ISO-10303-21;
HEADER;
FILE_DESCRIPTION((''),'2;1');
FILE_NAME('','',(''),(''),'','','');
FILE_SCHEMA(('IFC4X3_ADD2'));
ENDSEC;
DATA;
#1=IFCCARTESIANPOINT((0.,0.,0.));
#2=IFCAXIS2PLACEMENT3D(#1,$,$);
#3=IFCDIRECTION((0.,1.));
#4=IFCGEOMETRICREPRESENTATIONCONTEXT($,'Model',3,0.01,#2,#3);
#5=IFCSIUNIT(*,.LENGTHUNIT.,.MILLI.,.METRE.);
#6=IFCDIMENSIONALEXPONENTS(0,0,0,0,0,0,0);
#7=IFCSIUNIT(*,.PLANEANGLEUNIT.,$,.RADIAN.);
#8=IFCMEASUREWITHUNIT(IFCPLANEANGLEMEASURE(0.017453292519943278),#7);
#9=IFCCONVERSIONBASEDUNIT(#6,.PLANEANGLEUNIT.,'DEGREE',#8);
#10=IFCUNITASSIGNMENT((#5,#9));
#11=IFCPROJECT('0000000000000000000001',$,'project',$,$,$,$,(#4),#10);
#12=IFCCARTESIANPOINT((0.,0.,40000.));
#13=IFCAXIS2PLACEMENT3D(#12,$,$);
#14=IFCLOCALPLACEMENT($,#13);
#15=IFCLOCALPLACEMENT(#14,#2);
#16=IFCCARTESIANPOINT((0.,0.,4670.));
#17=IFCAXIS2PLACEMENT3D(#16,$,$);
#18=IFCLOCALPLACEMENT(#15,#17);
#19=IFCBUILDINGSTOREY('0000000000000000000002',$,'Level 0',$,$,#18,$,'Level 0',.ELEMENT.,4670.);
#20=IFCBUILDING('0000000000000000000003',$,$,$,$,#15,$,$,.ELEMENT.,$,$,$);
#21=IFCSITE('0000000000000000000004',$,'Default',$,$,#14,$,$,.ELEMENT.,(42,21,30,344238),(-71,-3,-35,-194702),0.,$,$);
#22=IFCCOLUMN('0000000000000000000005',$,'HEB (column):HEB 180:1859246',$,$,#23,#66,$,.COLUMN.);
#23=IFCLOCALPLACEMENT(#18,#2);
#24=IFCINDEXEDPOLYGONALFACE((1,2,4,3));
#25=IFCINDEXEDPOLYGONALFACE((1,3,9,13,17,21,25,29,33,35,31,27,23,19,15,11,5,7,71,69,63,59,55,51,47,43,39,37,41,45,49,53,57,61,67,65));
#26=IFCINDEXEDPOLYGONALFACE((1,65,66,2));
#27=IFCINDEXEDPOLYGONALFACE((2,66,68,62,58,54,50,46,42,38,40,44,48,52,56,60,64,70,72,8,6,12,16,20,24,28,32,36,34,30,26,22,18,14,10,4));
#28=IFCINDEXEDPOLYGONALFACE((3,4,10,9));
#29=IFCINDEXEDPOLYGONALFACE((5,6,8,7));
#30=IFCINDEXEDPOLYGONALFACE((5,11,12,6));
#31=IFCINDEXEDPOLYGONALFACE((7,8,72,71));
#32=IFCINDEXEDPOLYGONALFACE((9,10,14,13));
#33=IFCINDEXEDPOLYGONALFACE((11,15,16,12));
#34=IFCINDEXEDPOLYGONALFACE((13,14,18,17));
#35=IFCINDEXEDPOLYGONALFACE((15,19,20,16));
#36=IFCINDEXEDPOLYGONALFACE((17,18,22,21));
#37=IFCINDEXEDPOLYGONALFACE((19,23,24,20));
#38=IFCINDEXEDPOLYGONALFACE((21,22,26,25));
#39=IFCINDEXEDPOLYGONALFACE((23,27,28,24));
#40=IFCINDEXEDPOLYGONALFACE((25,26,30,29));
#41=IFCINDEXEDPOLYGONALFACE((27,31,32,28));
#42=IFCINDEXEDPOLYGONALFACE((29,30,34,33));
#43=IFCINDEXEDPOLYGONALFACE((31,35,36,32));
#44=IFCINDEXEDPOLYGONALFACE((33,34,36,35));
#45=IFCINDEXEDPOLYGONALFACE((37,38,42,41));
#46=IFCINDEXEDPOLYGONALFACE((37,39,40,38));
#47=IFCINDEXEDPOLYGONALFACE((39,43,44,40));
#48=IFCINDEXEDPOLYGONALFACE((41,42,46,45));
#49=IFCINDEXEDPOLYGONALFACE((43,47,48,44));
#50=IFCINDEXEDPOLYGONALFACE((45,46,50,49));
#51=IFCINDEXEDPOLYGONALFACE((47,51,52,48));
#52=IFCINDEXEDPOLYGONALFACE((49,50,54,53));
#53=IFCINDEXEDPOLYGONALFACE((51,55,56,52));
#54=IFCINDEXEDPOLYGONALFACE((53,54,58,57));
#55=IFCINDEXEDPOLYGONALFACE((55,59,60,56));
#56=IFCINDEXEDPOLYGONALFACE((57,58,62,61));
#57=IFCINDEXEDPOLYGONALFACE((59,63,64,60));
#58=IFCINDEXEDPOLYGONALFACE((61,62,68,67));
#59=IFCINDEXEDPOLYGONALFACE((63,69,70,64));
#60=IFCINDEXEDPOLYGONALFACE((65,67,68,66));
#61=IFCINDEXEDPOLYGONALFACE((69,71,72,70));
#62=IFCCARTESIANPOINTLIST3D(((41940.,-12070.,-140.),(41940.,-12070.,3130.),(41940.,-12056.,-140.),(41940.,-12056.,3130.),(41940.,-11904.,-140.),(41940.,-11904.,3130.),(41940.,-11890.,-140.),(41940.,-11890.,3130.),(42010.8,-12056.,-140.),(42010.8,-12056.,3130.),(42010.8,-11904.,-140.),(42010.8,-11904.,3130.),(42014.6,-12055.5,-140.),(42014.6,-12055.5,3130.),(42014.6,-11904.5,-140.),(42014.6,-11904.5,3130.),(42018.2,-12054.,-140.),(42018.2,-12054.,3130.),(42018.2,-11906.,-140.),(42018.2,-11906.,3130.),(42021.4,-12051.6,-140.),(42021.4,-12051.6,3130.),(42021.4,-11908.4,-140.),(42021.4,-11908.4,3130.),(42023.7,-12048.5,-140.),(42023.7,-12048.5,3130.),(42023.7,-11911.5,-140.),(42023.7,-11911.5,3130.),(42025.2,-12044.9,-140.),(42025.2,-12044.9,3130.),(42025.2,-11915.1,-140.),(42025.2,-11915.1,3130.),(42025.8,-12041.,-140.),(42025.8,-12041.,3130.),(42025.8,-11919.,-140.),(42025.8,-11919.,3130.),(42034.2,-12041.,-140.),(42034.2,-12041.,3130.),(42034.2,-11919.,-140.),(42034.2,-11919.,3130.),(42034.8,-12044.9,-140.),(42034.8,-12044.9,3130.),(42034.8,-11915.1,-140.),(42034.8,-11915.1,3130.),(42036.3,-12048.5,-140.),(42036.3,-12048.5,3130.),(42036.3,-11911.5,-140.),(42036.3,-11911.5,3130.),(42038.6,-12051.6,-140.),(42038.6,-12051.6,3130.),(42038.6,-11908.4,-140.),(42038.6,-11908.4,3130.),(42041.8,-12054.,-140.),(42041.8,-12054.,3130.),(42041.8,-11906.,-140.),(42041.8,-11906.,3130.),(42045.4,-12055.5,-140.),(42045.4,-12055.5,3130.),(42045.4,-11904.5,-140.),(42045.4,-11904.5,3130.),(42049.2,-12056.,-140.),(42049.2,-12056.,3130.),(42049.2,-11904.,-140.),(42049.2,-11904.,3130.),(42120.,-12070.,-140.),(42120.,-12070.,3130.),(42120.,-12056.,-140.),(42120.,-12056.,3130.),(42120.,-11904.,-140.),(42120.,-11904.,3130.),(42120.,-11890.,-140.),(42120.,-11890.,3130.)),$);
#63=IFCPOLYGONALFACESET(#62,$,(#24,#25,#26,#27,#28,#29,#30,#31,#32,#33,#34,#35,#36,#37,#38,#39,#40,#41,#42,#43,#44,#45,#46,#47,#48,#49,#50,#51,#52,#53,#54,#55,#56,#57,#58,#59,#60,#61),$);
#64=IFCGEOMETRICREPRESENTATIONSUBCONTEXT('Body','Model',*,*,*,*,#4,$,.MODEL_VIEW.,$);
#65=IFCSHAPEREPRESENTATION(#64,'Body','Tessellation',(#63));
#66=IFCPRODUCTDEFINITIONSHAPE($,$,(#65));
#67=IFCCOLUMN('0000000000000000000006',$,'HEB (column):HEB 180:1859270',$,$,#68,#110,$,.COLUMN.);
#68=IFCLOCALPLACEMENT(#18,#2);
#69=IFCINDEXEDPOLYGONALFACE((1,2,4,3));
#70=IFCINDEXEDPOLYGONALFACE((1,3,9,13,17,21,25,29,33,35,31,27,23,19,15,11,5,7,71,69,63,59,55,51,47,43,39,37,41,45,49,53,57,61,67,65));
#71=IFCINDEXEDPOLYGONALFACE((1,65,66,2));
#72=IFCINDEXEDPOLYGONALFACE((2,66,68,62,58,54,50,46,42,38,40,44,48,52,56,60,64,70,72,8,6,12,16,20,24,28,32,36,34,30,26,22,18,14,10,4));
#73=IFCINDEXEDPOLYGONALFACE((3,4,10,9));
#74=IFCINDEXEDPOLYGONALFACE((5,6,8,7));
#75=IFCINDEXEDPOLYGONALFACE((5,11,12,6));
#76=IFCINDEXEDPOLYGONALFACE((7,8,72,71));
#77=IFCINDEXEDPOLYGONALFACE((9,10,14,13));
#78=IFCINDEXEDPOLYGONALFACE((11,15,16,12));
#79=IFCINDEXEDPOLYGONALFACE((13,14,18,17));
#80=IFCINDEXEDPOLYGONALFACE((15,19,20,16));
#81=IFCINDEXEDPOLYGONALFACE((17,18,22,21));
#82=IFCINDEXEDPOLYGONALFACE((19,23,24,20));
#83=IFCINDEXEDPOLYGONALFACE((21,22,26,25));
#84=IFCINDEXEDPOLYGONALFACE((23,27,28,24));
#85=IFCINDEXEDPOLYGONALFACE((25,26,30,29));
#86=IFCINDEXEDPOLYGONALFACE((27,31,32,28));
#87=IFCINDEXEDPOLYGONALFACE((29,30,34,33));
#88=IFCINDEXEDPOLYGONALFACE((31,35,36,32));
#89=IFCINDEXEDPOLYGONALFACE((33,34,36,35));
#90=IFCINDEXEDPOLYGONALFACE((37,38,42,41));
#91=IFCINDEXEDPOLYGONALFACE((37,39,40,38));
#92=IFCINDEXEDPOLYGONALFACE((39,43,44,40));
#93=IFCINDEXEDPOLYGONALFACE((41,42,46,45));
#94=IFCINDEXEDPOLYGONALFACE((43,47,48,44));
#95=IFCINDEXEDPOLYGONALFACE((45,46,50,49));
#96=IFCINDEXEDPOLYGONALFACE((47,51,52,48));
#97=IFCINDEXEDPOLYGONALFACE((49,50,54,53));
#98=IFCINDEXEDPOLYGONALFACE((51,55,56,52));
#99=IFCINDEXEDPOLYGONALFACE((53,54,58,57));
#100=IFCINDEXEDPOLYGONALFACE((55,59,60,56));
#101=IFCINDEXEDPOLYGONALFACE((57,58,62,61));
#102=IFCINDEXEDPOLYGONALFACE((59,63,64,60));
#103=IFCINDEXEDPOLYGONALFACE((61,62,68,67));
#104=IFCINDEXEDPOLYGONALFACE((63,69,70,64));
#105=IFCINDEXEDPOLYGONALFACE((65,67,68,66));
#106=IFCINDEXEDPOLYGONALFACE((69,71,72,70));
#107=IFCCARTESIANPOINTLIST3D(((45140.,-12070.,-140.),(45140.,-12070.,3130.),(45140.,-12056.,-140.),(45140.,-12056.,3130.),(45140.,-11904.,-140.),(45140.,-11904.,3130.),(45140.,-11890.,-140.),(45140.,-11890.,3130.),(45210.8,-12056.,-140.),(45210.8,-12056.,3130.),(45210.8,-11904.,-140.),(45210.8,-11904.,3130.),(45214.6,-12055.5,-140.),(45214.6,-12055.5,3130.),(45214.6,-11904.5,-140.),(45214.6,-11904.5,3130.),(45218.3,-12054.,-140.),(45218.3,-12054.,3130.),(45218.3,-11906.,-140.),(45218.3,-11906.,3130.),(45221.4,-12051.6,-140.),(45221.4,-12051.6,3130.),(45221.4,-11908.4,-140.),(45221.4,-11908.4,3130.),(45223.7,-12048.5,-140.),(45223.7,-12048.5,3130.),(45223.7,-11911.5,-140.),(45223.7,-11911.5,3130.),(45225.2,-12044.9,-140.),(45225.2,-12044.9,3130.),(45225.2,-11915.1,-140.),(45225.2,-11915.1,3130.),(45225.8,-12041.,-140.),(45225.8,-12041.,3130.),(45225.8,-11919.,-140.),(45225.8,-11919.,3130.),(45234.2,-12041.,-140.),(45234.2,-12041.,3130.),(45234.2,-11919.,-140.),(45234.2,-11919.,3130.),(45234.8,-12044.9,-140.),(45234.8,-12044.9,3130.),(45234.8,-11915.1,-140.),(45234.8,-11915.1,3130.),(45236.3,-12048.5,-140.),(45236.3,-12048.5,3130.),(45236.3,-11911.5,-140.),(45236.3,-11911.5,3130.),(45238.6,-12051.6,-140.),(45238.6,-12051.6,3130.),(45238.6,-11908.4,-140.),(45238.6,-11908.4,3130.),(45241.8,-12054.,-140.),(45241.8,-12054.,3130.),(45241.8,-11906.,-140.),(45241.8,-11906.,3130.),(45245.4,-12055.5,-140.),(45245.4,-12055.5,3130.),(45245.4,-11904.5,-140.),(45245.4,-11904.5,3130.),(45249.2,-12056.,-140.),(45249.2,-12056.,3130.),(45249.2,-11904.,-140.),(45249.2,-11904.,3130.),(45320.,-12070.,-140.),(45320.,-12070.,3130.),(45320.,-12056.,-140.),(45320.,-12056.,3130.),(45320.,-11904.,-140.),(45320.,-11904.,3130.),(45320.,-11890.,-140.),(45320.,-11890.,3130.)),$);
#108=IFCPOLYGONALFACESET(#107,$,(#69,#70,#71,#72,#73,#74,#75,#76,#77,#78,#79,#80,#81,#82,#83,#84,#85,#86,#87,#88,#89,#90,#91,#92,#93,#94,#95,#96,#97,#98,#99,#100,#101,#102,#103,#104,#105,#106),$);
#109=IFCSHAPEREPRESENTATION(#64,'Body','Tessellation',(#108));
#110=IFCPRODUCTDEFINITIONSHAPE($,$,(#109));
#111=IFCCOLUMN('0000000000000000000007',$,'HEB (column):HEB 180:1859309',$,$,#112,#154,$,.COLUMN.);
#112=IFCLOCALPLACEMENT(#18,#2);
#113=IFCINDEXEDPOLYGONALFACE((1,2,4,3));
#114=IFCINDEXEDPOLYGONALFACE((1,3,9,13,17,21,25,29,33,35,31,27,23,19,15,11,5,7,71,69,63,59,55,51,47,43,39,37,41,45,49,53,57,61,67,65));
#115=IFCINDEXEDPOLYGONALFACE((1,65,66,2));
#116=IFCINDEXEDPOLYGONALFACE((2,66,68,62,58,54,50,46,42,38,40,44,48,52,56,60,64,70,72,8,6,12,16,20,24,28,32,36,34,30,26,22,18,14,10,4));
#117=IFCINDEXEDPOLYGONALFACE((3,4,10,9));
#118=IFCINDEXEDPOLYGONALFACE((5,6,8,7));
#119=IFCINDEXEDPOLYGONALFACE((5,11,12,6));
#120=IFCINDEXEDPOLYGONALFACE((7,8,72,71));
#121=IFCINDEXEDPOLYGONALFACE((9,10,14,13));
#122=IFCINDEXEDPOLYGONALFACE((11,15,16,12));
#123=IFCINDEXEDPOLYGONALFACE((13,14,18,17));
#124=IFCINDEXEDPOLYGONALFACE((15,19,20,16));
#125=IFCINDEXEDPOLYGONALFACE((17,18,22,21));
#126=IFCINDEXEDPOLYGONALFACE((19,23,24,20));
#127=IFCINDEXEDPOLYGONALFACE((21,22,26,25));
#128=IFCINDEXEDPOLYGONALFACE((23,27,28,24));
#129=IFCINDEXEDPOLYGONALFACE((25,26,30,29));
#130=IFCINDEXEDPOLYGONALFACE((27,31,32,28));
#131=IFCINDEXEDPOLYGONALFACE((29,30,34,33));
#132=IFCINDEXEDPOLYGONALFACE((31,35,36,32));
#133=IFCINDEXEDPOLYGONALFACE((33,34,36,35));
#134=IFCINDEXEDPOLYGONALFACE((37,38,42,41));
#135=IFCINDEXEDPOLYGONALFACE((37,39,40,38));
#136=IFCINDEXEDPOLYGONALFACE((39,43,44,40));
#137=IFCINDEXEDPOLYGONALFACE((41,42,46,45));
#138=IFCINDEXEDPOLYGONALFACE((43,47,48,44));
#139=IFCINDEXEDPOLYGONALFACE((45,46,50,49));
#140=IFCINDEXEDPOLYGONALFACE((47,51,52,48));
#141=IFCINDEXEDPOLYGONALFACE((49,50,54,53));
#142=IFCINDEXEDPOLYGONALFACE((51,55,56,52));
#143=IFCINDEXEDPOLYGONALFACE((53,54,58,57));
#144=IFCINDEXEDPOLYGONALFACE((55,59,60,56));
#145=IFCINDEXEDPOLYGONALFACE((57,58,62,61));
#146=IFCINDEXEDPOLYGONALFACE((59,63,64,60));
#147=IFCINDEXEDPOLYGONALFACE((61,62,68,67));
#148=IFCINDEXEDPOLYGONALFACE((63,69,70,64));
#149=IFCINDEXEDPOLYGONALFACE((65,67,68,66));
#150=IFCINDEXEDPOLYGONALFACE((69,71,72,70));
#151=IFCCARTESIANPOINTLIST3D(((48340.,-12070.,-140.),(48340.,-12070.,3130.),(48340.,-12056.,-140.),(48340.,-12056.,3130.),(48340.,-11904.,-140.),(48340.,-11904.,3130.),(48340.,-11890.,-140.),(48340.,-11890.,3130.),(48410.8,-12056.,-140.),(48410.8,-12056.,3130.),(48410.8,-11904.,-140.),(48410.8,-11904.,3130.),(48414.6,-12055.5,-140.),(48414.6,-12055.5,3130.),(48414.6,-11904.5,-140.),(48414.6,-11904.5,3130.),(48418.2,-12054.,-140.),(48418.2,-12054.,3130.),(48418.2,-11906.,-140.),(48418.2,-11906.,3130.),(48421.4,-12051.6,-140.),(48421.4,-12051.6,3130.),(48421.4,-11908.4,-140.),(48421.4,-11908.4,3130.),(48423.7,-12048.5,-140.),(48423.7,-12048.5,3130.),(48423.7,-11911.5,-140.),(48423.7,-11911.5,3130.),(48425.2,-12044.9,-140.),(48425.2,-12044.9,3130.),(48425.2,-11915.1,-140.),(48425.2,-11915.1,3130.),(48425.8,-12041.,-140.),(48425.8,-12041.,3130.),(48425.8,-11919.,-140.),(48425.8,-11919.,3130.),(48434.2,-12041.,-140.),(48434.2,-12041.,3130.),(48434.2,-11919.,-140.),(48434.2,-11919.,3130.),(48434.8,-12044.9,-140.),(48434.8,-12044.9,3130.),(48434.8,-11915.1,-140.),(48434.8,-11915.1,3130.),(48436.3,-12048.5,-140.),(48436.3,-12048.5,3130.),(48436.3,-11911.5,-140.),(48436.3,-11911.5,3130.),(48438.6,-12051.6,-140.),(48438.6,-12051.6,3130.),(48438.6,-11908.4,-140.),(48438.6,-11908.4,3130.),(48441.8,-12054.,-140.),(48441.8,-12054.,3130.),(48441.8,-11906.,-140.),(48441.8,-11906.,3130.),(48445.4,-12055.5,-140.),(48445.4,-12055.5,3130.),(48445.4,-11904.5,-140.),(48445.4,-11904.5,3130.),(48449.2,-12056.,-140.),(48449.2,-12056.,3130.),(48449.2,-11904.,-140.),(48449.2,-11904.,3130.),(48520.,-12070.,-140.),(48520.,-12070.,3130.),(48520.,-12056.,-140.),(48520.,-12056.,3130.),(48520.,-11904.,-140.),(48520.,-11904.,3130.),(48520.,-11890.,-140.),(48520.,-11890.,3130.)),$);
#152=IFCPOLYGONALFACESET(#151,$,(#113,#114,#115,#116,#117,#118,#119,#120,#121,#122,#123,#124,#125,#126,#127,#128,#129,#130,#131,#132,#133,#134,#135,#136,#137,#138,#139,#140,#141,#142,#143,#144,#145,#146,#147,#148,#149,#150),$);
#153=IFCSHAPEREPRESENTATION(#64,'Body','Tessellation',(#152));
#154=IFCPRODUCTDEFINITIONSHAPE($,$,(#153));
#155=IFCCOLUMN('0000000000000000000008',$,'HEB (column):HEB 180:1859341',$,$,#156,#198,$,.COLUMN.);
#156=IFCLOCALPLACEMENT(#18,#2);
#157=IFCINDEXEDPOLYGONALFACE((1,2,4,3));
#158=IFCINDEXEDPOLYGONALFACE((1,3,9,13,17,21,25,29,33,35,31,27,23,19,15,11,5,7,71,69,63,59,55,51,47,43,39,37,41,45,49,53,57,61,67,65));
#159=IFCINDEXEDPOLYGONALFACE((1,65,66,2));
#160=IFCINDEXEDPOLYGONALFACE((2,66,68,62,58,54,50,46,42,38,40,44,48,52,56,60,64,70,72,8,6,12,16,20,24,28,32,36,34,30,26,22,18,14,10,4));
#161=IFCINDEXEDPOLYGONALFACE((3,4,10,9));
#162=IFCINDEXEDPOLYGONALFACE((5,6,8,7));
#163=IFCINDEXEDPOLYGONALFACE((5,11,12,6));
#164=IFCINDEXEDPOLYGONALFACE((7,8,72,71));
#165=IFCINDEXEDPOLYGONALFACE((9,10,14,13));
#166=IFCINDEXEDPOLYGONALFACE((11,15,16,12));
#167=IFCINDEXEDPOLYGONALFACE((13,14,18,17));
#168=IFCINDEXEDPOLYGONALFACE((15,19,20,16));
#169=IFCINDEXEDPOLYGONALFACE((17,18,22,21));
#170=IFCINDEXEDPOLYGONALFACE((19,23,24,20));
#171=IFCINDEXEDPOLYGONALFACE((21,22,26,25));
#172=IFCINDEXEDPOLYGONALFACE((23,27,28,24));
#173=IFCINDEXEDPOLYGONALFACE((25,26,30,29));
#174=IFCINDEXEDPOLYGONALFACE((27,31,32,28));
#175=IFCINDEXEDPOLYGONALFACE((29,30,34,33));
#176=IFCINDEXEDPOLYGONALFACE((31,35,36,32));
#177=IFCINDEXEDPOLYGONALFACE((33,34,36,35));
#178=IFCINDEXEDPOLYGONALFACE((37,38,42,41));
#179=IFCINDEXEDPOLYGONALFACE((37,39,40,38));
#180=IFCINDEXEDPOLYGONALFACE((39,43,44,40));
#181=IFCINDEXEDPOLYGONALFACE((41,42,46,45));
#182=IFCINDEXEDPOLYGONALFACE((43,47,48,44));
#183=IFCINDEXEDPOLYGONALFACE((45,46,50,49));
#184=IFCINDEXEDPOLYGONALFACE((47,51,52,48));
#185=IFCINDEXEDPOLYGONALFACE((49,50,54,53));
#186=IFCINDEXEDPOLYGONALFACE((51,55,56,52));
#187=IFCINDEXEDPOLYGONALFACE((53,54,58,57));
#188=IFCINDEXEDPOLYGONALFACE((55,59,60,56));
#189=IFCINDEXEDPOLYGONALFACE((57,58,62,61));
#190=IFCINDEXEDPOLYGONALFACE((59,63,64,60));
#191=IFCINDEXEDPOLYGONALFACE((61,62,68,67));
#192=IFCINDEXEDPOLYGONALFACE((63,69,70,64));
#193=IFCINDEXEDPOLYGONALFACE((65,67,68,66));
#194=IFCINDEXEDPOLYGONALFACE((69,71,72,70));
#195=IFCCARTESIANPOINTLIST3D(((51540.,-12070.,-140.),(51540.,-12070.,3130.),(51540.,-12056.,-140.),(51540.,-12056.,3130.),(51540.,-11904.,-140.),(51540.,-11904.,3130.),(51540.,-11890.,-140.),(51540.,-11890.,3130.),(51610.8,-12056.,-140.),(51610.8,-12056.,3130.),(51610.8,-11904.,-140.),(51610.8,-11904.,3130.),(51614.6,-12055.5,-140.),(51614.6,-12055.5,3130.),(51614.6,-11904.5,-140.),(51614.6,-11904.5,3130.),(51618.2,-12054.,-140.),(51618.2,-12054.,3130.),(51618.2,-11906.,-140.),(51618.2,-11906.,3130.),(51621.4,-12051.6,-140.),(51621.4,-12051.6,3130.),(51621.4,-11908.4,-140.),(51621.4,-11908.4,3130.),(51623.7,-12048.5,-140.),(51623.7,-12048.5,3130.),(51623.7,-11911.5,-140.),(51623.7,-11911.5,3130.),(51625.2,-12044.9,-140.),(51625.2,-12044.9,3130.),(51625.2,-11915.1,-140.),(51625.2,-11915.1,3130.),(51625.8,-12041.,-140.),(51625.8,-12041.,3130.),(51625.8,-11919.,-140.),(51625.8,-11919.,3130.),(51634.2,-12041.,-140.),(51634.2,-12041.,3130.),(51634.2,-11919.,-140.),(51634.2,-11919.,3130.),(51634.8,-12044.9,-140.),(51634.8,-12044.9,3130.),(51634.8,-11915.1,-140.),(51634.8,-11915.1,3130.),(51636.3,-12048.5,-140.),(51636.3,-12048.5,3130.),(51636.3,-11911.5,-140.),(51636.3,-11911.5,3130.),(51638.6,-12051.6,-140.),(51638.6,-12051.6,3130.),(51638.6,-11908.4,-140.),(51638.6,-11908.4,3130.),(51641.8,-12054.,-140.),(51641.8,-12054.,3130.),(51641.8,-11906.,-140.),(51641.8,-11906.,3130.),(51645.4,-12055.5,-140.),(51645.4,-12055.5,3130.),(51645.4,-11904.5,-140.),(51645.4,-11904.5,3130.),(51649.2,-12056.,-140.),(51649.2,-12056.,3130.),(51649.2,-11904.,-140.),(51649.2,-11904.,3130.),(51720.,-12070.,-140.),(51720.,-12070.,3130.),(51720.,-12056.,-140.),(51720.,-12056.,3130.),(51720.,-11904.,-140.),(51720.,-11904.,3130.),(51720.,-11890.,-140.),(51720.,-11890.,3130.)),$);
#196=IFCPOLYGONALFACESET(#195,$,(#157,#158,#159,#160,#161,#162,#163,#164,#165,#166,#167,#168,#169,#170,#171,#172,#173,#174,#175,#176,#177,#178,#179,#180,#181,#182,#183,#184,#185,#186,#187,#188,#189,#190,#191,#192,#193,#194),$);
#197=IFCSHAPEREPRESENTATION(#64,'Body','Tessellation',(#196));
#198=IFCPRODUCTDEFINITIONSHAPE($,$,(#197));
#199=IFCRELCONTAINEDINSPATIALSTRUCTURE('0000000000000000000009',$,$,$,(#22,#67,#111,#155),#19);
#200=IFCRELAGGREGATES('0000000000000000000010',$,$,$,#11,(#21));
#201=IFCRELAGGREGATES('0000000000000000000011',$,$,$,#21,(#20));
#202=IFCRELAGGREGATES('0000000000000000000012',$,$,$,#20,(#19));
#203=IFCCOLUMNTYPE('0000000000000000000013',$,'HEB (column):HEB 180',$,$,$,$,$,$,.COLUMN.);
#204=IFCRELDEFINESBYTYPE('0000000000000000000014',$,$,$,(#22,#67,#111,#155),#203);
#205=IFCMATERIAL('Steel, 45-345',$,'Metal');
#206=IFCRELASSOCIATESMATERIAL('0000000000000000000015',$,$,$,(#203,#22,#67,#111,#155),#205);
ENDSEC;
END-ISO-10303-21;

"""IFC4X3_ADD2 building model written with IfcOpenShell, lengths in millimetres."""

from ifc_helpers import new_model, entity, si_unit, converted_unit, direction, frame, origin, origin_2d_with_axis, place, context, subcontext, project, spatial, i_section, extrude, source, transform, mapped, material, material_profile, profile_set, profile_usage, type_object, type_shapes, element, save


model = new_model("IFC4X3_ADD2")

# Units and contexts
model_context = context("Model", 3, precision=0.01, world=origin(), true_north=direction((0.0, 1.0)))
body_context = subcontext(model_context, "Body", "Model", "MODEL_VIEW")
ifc_project = project(units=[si_unit("LENGTHUNIT", "METRE", prefix="MILLI"), converted_unit("PLANEANGLEUNIT", "DEGREE", entity("IfcPlaneAngleMeasure", 0.017453292519943278), si_unit("PLANEANGLEUNIT", "RADIAN"), dimensions=[0, 0, 0, 0, 0, 0, 0])], contexts=[model_context])

# Site, building, storey
site_placement = place(None, frame((0.0, 0.0, 40000.0)))
site = spatial("IfcSite", under=ifc_project, at=site_placement, Name="Default", CompositionType="ELEMENT", RefLatitude=(42, 21, 30, 344238), RefLongitude=(-71, -3, -35, -194702), RefElevation=0.0)
building_placement = place(site_placement, origin())
building = spatial("IfcBuilding", under=site, at=building_placement, CompositionType="ELEMENT")
storey_placement = place(building_placement, frame((0.0, 0.0, 4670.0)))
storey = spatial("IfcBuildingStorey", under=building, at=storey_placement, Name="Level 0", LongName="Level 0", CompositionType="ELEMENT", Elevation=4670.0)

# Columns
ifc_material_1 = material(Name="Steel, 45-345", Category="Metal")
ifc_material_profile_1 = material_profile(ifc_material_1, i_section(OverallWidth=180.0, OverallDepth=180.0, WebThickness=8.5, FlangeThickness=14.0, FilletRadius=15.0, at=origin_2d_with_axis()), Name="HEB 180")
ifc_profile_set_1 = profile_set([ifc_material_profile_1], Name="HEB 180")
ifc_profile_usage_1 = profile_usage(ifc_profile_set_1)
column_type = type_object("IfcColumnType", Name="HEB (column):HEB 180", PredefinedType="COLUMN", material=ifc_profile_set_1)
shared_shape_1 = source(origin(), body_context, "Body", "SweptSolid", [
    extrude(i_section(OverallWidth=180.0, OverallDepth=180.0, WebThickness=8.5, FlangeThickness=14.0, FilletRadius=15.0, at=origin_2d_with_axis()), frame((0.0, 0.0, 4530.0), z_axis=(0.0, 0.0, 1.0), x_axis=(-1.0, 0.0, 0.0)), (0.0, 0.0, 1.0), 3270.0),
])
type_shapes(column_type, [shared_shape_1])
for number, where, name in (
    (1, (42030.0, -11980.0, -4670.0), "HEB (column):HEB 180:1859246"),
    (2, (45230.0, -11980.0, -4670.0), "HEB (column):HEB 180:1859270"),
    (3, (48430.0, -11980.0, -4670.0), "HEB (column):HEB 180:1859309"),
    (4, (51630.0, -11980.0, -4670.0), "HEB (column):HEB 180:1859341"),
):
    element("IfcColumn", number, at=place(storey_placement, frame(where)), inside=storey, type_object=column_type, material=ifc_profile_usage_1, Name=name, PredefinedType="COLUMN", context=body_context, shape_type="MappedRepresentation", body=[
        mapped(shared_shape_1, transform((0.0, 0.0, 0.0), scale=1.0)),
    ])

save(model, "model.ifc")
